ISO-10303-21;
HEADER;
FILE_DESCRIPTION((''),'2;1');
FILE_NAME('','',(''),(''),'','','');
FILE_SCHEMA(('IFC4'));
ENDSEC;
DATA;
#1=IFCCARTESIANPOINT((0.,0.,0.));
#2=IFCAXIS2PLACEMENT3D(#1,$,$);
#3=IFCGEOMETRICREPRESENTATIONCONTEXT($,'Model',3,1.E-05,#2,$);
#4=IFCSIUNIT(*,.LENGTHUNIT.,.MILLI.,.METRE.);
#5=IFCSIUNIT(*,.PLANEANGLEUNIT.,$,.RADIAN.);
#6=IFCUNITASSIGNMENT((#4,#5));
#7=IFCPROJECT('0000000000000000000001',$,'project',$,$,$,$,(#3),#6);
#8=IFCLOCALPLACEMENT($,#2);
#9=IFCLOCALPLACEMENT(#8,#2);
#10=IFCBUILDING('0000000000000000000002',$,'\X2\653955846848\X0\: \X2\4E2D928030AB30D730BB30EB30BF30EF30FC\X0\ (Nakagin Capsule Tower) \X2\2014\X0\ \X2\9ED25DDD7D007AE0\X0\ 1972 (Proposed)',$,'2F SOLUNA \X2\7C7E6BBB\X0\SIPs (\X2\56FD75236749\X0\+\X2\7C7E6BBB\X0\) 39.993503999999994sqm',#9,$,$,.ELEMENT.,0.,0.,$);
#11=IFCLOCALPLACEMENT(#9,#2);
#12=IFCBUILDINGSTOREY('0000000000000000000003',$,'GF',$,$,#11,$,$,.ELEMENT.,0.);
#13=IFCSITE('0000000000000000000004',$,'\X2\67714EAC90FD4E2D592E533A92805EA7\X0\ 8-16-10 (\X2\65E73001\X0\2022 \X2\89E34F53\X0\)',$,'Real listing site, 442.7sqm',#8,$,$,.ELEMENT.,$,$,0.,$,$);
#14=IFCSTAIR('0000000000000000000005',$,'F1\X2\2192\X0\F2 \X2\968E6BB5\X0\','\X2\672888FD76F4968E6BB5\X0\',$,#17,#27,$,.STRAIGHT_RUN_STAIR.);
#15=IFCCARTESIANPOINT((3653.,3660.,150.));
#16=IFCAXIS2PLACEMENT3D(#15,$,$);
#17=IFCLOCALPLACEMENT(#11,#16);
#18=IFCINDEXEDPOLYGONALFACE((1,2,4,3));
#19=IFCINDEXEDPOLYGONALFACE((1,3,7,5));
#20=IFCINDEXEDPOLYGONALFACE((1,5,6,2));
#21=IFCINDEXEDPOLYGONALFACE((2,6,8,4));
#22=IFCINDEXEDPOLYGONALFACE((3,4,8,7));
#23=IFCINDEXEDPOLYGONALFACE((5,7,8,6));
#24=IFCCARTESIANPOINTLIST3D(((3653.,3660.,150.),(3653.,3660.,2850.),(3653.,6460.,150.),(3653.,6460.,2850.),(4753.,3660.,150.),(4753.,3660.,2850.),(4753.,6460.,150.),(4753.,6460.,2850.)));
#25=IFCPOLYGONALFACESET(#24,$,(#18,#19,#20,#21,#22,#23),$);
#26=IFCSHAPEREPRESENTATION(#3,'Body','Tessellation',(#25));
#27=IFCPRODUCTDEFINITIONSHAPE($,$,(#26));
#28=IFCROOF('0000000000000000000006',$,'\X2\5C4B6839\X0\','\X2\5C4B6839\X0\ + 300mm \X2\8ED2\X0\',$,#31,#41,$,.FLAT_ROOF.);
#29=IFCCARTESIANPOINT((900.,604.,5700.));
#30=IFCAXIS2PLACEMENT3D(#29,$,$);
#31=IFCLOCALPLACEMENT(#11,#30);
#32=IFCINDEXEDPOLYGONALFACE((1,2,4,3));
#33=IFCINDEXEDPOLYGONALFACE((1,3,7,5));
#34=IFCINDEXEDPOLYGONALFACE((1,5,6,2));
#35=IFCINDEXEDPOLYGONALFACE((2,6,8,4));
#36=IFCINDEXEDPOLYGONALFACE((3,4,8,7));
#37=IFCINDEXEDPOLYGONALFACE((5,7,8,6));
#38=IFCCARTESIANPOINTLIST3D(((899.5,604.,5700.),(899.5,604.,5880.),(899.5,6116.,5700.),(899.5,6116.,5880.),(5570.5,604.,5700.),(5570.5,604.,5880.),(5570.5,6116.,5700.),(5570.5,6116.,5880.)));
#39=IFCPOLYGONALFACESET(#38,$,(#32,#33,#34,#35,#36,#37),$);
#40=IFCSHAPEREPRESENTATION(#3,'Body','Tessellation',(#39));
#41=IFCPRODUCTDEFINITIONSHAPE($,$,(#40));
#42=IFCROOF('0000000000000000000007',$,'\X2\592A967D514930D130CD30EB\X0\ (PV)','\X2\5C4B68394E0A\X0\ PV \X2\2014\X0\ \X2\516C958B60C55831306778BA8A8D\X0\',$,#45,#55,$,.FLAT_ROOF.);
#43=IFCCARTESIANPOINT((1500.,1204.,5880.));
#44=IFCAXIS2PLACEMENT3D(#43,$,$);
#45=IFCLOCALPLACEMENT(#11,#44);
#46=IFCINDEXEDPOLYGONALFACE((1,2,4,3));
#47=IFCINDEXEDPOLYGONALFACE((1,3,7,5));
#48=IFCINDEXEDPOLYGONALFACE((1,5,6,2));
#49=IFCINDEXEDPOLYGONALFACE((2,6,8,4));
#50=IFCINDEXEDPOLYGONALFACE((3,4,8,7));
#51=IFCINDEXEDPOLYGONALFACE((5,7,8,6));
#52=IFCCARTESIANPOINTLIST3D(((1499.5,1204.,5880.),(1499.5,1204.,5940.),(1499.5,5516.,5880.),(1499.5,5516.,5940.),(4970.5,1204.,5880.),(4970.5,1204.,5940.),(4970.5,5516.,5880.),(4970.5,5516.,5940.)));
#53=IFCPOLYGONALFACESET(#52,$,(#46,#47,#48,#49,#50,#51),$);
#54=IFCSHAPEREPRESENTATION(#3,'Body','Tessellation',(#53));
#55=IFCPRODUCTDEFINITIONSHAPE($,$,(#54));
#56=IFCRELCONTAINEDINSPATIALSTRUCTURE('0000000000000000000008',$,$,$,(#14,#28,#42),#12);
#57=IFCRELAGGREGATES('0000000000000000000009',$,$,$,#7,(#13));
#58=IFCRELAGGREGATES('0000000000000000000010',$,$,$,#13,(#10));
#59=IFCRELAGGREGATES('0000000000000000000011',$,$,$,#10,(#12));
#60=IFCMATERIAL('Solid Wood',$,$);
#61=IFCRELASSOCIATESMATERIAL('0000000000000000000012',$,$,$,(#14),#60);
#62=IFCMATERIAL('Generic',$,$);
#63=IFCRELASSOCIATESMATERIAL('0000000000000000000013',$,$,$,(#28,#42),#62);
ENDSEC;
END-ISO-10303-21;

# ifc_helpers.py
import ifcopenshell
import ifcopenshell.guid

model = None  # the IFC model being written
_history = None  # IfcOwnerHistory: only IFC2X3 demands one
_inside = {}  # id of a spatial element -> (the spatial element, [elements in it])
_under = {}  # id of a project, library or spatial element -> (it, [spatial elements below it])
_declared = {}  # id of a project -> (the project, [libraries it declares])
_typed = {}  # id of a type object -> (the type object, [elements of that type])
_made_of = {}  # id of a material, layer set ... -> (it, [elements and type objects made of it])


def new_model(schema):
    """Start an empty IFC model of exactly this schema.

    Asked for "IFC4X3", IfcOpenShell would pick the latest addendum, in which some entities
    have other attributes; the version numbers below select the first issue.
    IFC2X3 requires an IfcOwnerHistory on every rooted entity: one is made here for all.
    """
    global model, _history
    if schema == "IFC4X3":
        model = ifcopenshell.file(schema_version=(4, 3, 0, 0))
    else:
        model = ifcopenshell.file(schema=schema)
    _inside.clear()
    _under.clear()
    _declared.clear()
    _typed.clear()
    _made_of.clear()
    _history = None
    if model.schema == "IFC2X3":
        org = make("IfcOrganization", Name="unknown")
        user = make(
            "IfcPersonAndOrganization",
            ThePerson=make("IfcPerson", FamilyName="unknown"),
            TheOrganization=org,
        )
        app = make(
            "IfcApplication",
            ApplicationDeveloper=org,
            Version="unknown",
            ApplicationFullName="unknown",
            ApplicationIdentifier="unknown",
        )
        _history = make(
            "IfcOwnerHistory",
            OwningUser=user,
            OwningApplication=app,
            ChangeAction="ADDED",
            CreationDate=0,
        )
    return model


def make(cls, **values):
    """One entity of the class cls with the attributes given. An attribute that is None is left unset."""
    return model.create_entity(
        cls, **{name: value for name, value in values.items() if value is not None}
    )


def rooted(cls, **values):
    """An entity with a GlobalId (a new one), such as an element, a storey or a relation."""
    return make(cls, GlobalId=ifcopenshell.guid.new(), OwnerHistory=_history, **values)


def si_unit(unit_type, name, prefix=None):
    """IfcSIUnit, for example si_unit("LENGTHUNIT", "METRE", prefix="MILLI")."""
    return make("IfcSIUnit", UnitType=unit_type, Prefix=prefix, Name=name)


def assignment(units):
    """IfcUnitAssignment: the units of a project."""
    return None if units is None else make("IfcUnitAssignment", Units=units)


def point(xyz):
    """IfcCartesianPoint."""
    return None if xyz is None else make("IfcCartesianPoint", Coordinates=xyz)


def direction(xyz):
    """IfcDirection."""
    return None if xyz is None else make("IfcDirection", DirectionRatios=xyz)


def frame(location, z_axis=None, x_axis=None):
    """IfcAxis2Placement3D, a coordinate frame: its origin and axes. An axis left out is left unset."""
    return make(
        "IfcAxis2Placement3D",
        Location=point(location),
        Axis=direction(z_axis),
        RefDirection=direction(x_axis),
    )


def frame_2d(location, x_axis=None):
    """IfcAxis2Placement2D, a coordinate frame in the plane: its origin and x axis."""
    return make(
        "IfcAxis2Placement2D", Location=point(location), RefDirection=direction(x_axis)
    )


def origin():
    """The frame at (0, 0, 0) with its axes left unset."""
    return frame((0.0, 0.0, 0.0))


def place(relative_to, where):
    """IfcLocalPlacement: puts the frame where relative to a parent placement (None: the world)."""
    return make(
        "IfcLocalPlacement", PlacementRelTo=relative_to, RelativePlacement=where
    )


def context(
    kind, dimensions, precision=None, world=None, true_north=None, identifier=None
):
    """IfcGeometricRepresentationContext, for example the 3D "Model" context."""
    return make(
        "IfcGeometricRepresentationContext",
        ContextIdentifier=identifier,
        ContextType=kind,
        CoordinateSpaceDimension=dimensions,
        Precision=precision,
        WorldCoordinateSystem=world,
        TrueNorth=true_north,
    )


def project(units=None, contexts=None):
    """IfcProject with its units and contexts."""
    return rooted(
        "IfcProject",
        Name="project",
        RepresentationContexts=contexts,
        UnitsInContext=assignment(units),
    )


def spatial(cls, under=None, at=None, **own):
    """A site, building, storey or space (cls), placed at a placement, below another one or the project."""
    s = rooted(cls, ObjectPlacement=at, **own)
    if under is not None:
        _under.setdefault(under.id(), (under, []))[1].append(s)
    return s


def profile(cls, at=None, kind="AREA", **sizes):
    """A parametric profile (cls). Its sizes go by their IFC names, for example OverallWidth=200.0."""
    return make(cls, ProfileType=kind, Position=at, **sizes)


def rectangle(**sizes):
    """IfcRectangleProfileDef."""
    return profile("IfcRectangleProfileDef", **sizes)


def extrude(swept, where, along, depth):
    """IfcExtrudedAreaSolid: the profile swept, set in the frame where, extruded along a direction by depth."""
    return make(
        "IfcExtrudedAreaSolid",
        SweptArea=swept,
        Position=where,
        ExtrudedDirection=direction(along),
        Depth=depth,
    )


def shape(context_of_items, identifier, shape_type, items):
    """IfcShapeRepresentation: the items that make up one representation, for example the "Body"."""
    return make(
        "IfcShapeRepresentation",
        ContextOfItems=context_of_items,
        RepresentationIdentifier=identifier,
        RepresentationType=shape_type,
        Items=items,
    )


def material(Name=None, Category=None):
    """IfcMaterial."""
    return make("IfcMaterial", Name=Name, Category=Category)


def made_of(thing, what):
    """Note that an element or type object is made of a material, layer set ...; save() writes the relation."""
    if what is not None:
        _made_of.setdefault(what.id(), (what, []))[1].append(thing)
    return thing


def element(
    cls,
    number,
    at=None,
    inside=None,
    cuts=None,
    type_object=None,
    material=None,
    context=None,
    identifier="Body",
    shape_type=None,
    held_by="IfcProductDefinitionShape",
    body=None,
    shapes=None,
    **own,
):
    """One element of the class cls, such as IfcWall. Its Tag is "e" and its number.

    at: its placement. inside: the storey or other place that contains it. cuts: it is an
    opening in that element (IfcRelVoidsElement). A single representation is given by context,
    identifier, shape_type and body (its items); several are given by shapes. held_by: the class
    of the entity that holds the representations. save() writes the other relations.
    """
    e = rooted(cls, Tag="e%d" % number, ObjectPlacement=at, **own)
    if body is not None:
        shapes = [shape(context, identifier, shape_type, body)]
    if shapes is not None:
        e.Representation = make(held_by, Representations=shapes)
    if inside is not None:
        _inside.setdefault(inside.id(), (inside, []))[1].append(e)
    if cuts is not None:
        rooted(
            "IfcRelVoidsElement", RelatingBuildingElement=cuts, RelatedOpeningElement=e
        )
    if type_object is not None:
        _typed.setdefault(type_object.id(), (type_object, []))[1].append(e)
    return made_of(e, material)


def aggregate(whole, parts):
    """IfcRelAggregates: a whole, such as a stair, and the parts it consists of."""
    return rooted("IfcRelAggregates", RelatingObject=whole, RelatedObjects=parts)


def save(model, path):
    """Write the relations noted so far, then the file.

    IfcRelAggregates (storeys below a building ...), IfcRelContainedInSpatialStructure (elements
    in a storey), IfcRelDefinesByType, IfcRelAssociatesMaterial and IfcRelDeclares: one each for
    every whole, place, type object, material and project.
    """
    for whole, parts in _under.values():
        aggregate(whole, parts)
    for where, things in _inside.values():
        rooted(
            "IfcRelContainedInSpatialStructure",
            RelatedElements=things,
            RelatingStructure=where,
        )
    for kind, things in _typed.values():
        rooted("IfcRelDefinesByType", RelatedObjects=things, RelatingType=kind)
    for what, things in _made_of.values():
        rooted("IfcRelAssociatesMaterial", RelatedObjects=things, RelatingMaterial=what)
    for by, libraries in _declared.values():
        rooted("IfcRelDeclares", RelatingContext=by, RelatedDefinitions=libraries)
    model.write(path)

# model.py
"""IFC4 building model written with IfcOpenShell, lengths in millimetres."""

from ifc_helpers import new_model, si_unit, frame, frame_2d, origin, place, context, project, spatial, rectangle, extrude, material, element, save


model = new_model("IFC4")

# Units and contexts
model_context = context("Model", 3, precision=1e-05, world=origin())
ifc_project = project(units=[si_unit("LENGTHUNIT", "METRE", prefix="MILLI"), si_unit("PLANEANGLEUNIT", "RADIAN")], contexts=[model_context])

# Site, building, storey
site_placement = place(None, origin())
site = spatial("IfcSite", under=ifc_project, at=site_placement, Name="東京都中央区銀座 8-16-10 (旧、2022 解体)", ObjectType="Real listing site, 442.7sqm", CompositionType="ELEMENT", RefElevation=0.0)
building_placement = place(site_placement, origin())
building = spatial("IfcBuilding", under=site, at=building_placement, Name="改善案: 中銀カプセルタワー (Nakagin Capsule Tower) — 黒川紀章 1972 (Proposed)", ObjectType="2F SOLUNA 籾殻SIPs (国産杉+籾殻) 39.993503999999994sqm", CompositionType="ELEMENT", ElevationOfRefHeight=0.0, ElevationOfTerrain=0.0)
storey_placement = place(building_placement, origin())
storey = spatial("IfcBuildingStorey", under=building, at=storey_placement, Name="GF", CompositionType="ELEMENT", Elevation=0.0)

# Shared definitions
ifc_material_1 = material(Name="Generic")

# Shared definitions
ifc_material_2 = material(Name="Solid Wood")

# Stair
stair_placement = place(storey_placement, frame((3653.0, 3660.0, 150.0)))
element("IfcStair", 1, at=stair_placement, inside=storey, material=ifc_material_2, Name="F1→F2 階段", Description="木製直階段", PredefinedType="STRAIGHT_RUN_STAIR", context=model_context, shape_type="SweptSolid", body=[
    extrude(rectangle(XDim=1100.0, YDim=2800.0, at=frame_2d((550.0, 1400.0))), frame((3653.0, 3660.0, 150.0)), (0.0, 0.0, 1.0), 2700.0),
])

# Roofs
roof_1_placement = place(storey_placement, frame((900.0, 604.0, 5700.0)))
element("IfcRoof", 2, at=roof_1_placement, inside=storey, material=ifc_material_1, Name="屋根", Description="屋根 + 300mm 軒", PredefinedType="FLAT_ROOF", context=model_context, shape_type="SweptSolid", body=[
    extrude(rectangle(XDim=4671.0, YDim=5512.0, at=frame_2d((2335.0, 2756.0))), frame((900.0, 604.0, 5700.0)), (0.0, 0.0, 1.0), 180.0),
])
roof_2_placement = place(storey_placement, frame((1500.0, 1204.0, 5880.0)))
element("IfcRoof", 3, at=roof_2_placement, inside=storey, material=ifc_material_1, Name="太陽光パネル (PV)", Description="屋根上 PV — 公開情報で確認", PredefinedType="FLAT_ROOF", context=model_context, shape_type="SweptSolid", body=[
    extrude(rectangle(XDim=3471.0, YDim=4312.0, at=frame_2d((1735.0, 2156.0))), frame((1500.0, 1204.0, 5880.0)), (0.0, 0.0, 1.0), 60.0),
])

save(model, "model.ifc")
